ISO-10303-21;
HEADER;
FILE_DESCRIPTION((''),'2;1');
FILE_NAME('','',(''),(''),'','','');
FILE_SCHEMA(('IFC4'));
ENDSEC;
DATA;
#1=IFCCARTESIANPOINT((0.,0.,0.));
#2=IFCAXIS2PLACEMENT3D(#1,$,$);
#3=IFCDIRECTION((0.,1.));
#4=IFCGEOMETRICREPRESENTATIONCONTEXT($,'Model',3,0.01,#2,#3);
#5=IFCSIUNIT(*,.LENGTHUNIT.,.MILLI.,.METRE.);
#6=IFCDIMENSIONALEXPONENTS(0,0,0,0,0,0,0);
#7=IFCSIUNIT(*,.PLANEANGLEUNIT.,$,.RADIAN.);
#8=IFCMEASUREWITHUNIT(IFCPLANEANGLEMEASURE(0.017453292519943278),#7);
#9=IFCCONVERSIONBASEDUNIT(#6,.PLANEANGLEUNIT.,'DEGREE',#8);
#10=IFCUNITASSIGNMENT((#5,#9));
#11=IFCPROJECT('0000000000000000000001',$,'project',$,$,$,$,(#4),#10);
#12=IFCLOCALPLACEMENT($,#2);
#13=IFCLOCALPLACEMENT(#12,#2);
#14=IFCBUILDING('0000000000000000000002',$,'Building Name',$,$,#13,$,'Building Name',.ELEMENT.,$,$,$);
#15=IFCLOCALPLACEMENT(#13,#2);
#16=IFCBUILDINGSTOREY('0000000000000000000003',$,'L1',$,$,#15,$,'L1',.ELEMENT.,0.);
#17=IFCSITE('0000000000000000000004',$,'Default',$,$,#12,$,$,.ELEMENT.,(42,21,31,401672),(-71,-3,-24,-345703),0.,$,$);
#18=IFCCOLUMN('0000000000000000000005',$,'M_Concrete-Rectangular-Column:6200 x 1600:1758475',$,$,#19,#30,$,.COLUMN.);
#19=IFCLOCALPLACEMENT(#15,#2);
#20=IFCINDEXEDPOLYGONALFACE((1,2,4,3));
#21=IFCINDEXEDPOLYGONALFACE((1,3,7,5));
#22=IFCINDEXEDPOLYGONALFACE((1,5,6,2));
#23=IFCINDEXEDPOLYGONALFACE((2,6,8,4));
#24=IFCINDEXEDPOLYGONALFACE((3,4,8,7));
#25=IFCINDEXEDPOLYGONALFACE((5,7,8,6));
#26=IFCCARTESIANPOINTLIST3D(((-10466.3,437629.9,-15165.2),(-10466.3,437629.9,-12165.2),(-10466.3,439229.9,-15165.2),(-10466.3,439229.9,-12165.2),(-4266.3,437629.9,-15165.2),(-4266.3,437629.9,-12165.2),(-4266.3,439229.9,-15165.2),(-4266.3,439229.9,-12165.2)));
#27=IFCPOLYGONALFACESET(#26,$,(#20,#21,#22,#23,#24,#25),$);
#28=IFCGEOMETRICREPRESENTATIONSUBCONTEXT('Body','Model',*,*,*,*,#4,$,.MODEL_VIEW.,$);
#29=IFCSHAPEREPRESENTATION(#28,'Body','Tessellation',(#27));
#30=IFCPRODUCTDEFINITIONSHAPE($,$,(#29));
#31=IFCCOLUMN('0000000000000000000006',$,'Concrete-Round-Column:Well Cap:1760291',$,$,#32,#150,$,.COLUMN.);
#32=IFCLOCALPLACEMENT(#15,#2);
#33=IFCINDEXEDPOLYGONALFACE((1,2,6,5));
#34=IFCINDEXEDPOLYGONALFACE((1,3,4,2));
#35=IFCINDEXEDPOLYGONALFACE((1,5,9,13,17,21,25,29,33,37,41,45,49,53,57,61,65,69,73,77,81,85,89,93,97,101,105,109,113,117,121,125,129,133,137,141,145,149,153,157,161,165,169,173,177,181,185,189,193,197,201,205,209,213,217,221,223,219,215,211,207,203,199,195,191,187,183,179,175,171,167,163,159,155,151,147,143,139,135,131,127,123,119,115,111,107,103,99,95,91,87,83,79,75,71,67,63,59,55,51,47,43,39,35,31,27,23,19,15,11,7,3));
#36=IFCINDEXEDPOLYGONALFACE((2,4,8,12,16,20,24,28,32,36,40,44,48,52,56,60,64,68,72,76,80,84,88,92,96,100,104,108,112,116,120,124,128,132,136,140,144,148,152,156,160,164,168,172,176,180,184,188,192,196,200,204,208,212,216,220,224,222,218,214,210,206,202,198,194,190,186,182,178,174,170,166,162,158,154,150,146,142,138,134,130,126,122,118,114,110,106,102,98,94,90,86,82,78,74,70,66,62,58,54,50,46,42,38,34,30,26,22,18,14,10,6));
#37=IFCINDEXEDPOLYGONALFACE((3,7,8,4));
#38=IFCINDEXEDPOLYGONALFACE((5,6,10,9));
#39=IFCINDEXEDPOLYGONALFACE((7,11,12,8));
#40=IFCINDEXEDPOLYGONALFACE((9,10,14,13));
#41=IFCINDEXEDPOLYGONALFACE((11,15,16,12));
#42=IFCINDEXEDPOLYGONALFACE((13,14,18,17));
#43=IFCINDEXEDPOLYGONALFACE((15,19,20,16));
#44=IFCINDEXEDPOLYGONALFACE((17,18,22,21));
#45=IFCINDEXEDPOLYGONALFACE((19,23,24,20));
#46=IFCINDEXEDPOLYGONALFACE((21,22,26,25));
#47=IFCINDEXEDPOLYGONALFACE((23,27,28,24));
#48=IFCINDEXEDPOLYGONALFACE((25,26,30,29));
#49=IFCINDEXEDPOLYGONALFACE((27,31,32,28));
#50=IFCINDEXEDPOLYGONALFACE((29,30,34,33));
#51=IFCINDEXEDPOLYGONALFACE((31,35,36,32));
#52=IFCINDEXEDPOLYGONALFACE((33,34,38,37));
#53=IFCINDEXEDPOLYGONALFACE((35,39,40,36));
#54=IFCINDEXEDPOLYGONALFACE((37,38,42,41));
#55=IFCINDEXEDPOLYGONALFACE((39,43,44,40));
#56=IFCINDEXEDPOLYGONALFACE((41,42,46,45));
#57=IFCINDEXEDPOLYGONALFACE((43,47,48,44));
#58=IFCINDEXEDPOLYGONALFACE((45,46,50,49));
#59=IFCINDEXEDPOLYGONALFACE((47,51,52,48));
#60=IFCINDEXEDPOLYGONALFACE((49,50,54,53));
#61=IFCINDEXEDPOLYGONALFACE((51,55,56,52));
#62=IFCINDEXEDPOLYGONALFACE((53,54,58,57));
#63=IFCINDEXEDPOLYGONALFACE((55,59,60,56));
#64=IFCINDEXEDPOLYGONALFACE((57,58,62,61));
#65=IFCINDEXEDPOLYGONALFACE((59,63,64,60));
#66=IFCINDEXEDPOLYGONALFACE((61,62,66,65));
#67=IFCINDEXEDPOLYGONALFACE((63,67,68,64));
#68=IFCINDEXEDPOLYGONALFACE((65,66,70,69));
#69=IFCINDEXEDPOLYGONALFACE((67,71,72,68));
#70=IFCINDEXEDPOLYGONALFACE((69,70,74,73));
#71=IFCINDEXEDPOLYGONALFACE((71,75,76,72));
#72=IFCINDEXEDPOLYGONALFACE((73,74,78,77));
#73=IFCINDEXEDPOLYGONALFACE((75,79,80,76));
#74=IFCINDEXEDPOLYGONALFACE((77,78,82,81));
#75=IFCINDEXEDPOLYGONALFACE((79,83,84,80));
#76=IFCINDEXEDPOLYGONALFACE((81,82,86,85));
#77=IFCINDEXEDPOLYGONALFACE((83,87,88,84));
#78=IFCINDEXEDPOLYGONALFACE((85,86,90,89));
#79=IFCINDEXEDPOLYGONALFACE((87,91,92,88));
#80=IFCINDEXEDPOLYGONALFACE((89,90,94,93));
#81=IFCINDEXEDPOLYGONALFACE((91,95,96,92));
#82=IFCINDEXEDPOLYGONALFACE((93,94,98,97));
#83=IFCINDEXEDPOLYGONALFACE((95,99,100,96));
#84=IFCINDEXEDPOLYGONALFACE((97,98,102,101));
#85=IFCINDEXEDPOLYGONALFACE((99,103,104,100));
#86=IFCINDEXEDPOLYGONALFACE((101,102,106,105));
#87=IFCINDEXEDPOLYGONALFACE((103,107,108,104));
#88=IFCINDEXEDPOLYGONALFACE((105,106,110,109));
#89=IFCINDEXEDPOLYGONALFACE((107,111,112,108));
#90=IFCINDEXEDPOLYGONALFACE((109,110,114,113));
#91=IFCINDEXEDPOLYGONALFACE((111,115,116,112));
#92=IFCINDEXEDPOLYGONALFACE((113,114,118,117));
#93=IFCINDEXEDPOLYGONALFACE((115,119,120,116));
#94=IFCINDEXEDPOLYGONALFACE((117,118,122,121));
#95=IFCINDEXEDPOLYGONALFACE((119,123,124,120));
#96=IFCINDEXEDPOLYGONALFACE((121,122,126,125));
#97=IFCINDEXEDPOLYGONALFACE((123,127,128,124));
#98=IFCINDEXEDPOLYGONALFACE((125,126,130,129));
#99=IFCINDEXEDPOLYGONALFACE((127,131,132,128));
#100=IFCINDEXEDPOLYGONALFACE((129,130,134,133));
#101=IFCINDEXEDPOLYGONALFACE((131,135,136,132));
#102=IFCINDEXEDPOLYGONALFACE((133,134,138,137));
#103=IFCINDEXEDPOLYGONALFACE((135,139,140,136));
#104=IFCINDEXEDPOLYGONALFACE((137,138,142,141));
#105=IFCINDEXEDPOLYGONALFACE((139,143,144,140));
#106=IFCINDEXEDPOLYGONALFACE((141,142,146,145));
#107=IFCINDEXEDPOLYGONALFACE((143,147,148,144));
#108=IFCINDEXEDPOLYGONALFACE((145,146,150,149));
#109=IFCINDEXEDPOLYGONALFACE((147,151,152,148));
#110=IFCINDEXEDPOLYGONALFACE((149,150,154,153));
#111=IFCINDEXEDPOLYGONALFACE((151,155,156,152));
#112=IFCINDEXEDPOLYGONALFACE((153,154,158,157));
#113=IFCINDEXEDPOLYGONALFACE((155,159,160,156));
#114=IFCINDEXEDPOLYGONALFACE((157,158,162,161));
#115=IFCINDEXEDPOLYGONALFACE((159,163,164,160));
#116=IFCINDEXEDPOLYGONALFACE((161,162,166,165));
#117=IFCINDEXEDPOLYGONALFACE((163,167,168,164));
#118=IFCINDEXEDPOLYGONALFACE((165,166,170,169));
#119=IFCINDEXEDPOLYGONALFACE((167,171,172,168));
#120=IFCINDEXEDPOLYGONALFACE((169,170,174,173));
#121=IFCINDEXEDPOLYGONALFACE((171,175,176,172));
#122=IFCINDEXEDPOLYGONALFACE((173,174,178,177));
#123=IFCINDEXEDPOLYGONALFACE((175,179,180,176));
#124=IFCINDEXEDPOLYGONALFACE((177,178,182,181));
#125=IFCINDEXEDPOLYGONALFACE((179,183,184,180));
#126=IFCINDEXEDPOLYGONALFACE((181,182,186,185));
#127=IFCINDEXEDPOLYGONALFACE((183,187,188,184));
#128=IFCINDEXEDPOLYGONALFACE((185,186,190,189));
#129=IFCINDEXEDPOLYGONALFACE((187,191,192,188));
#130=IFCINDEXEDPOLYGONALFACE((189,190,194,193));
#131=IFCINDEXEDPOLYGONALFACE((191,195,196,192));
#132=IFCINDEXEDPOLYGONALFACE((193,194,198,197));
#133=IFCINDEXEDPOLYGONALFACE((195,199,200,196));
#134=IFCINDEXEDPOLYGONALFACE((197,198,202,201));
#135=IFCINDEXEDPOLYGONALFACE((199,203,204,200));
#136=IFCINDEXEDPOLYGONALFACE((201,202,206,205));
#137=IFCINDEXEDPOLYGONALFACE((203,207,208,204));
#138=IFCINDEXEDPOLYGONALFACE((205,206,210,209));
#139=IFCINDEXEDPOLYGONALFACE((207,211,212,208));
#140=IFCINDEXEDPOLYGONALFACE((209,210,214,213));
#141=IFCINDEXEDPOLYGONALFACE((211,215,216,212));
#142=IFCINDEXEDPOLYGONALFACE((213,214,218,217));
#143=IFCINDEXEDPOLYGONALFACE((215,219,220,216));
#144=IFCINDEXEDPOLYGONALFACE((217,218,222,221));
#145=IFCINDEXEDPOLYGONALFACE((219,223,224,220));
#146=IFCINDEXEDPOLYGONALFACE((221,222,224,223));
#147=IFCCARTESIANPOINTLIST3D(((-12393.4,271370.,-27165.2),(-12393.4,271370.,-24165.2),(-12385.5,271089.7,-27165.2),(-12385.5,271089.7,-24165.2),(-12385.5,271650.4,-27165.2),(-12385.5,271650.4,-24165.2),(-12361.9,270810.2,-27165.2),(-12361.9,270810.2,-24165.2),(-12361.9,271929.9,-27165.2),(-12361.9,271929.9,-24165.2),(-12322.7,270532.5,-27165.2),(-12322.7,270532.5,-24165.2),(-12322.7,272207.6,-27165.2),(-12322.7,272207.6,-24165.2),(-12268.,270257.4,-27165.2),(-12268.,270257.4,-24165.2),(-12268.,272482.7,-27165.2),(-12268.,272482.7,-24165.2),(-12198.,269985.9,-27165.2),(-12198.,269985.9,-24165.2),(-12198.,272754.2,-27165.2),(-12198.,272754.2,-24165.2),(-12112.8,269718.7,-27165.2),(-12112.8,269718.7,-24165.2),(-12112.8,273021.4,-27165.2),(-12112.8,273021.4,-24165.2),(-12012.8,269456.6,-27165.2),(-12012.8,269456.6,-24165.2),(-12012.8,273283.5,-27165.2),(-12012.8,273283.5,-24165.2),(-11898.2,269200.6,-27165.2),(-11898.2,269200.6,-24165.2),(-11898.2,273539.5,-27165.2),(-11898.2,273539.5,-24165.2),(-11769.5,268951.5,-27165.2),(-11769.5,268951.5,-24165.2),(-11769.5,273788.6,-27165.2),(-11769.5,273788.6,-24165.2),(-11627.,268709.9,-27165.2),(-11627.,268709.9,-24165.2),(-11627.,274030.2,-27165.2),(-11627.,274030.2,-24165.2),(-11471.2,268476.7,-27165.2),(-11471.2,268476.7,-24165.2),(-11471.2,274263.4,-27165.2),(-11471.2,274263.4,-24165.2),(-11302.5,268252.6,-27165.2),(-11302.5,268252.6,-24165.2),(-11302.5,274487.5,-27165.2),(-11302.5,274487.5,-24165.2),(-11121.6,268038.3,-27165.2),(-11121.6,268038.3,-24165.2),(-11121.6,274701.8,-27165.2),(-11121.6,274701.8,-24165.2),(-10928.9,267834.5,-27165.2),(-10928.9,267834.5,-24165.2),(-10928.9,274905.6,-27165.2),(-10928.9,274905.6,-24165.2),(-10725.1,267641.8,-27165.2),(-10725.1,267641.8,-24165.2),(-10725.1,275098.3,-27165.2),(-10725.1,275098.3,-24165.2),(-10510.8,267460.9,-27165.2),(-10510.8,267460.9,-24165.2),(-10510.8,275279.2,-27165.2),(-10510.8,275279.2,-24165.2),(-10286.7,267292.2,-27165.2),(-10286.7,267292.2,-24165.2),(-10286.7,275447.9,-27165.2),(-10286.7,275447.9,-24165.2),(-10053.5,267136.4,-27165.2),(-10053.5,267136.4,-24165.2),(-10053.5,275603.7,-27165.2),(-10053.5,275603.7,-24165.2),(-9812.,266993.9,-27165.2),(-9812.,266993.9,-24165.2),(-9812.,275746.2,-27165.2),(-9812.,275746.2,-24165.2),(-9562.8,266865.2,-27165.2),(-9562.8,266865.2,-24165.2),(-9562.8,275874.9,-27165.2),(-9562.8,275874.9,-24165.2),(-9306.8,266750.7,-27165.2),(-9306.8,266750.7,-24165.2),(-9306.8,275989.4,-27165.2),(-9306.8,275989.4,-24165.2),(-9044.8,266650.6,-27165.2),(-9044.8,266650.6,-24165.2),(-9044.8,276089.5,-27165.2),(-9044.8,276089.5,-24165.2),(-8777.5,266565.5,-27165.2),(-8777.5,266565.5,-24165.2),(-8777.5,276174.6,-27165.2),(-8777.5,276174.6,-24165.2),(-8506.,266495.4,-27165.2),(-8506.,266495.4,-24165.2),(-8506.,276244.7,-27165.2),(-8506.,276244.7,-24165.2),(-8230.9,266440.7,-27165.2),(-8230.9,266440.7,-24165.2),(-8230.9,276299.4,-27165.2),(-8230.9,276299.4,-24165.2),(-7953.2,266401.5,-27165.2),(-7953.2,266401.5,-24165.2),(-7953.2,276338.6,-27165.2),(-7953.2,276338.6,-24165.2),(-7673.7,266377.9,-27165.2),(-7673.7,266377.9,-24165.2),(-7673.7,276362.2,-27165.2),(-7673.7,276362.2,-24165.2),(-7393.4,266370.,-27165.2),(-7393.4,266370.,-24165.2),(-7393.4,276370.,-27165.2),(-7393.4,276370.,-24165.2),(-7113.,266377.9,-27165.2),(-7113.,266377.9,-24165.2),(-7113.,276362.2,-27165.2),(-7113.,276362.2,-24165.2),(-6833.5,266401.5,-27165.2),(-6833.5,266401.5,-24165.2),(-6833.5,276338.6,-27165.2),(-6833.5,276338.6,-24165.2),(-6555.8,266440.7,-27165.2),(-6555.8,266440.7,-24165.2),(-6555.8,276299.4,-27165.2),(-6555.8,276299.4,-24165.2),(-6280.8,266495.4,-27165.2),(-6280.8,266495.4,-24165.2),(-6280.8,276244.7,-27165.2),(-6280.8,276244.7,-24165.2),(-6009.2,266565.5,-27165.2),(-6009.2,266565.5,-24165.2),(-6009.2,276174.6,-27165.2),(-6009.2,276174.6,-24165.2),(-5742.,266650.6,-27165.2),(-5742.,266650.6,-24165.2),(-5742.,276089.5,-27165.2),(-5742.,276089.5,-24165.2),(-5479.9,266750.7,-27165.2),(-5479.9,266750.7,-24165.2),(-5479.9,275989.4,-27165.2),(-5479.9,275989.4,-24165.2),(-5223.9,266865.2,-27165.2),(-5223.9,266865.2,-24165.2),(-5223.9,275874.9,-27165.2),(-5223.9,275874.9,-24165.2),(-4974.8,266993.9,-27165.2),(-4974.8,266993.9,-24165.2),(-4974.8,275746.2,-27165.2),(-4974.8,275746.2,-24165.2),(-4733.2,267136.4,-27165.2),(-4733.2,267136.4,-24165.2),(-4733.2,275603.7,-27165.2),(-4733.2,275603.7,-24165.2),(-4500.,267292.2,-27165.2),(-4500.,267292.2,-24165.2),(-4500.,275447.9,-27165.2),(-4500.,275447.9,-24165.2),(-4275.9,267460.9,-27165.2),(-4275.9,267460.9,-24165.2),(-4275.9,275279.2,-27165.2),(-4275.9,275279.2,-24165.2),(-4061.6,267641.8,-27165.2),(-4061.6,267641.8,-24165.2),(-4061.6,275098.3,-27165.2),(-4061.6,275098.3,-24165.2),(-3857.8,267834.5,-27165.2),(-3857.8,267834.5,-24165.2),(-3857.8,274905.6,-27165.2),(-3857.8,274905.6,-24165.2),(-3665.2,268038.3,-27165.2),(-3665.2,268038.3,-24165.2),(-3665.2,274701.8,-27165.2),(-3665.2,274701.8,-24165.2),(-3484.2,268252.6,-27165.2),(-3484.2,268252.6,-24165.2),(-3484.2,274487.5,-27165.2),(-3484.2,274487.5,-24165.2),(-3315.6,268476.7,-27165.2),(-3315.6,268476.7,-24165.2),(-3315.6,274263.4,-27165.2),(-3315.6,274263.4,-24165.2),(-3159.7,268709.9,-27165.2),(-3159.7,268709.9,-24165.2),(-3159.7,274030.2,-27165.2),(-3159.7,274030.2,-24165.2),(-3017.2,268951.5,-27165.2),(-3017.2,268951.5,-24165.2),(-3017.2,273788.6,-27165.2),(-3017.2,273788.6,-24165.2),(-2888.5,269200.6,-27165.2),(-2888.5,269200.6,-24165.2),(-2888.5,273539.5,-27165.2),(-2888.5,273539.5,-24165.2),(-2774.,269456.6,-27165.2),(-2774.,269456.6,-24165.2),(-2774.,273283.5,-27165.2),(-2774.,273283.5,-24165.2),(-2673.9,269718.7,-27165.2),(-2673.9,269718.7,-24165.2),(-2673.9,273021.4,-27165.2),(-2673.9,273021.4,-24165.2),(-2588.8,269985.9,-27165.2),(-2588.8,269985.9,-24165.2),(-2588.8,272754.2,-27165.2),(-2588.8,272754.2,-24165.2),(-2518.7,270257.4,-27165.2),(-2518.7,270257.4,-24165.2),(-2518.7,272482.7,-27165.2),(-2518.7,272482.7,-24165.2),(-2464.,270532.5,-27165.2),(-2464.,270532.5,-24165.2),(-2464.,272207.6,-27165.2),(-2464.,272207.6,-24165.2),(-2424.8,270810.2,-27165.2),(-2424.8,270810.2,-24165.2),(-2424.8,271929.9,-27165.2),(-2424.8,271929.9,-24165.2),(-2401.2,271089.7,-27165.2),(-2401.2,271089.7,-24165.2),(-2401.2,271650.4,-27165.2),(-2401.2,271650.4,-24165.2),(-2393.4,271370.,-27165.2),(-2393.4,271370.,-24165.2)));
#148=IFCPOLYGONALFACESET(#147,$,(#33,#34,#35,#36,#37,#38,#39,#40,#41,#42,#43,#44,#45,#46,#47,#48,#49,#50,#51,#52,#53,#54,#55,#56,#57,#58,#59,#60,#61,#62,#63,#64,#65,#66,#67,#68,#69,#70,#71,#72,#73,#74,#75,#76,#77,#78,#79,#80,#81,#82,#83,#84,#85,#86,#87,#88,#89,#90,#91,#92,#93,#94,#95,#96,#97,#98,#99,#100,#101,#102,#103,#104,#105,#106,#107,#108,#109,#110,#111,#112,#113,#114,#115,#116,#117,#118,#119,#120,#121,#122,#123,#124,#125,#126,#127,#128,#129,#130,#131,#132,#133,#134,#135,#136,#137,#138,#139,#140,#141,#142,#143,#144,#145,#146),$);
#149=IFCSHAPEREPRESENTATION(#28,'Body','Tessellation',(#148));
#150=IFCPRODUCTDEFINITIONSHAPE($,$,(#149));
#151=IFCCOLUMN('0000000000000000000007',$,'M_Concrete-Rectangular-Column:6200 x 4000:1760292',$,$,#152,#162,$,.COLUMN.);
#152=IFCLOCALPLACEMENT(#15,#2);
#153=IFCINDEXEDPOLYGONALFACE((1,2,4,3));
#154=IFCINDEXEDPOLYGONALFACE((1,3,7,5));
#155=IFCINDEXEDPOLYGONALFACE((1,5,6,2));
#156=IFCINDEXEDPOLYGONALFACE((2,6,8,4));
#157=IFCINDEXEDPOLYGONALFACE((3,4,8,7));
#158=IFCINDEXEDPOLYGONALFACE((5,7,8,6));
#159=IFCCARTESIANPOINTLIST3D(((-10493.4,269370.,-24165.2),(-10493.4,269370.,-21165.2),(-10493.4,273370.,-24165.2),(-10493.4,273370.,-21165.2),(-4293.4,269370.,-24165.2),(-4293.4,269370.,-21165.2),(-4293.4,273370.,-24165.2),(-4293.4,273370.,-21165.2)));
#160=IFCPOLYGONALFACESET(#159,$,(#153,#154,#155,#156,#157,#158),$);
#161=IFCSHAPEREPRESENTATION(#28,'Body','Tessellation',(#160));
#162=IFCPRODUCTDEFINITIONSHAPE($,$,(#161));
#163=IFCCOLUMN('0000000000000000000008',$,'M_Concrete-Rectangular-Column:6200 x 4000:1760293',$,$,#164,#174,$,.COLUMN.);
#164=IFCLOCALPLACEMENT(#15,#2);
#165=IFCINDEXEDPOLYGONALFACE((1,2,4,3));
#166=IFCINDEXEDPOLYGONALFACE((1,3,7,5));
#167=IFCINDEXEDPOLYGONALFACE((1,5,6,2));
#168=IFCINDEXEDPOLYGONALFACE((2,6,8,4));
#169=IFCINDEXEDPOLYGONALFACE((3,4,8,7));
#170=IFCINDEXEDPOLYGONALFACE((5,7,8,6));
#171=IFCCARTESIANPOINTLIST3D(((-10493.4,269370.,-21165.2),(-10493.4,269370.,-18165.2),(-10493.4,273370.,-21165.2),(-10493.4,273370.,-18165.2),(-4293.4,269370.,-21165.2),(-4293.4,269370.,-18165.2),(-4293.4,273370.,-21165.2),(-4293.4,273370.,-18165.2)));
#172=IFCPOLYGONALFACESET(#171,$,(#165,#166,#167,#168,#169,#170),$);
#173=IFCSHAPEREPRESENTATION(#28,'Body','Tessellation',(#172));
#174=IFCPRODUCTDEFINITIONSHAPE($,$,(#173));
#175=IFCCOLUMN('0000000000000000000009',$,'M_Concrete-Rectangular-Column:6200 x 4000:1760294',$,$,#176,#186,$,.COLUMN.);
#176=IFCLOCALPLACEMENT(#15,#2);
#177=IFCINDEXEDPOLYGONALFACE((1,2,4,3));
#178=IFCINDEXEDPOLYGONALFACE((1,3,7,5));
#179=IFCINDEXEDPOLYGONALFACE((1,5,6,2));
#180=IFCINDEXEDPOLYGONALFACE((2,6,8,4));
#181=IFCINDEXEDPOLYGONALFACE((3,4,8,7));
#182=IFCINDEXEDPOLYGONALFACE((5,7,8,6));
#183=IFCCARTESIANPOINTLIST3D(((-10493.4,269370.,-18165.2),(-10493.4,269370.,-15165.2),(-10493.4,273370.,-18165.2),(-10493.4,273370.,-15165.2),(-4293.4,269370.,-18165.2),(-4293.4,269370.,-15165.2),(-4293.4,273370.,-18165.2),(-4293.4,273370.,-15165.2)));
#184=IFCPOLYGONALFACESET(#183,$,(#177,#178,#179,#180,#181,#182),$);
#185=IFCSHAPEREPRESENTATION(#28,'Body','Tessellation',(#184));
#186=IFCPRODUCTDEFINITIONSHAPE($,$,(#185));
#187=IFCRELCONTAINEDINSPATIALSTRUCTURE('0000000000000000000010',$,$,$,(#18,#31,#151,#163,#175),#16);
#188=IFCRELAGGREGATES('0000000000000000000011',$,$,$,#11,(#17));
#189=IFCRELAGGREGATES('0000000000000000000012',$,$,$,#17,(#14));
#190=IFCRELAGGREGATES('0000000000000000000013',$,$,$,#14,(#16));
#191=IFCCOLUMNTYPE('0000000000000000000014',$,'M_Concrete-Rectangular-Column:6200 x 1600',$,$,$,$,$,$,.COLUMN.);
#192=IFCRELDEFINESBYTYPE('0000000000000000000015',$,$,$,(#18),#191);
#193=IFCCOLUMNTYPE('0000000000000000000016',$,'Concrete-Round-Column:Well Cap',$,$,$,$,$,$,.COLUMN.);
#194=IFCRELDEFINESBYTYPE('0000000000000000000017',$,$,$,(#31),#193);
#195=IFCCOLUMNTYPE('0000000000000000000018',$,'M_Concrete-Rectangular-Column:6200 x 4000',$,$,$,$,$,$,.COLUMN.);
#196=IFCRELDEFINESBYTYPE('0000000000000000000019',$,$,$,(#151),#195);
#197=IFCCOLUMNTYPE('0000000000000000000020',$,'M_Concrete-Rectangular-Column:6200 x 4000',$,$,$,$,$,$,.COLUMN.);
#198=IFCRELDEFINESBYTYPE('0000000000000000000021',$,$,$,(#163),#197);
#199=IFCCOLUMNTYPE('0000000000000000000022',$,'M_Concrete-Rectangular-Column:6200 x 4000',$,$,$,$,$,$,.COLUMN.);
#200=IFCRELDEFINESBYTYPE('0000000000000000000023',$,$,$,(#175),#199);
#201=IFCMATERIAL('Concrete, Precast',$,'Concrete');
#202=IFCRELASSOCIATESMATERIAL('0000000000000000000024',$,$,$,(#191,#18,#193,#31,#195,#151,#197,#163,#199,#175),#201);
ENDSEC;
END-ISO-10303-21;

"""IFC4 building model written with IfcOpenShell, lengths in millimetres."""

from ifc_helpers import new_model, entity, si_unit, converted_unit, direction, frame, origin, place, context, subcontext, project, spatial, arc, indexed_curve, outline, extrude, source, transform, mapped, material, type_object, type_shapes, element, save


model = new_model("IFC4")

# Units and contexts
model_context = context("Model", 3, precision=0.01, world=origin(), true_north=direction((0.0, 1.0)))
body_context = subcontext(model_context, "Body", "Model", "MODEL_VIEW")
ifc_project = project(units=[si_unit("LENGTHUNIT", "METRE", prefix="MILLI"), converted_unit("PLANEANGLEUNIT", "DEGREE", entity("IfcPlaneAngleMeasure", 0.017453292519943278), si_unit("PLANEANGLEUNIT", "RADIAN"), dimensions=[0, 0, 0, 0, 0, 0, 0])], contexts=[model_context])

# Site, building, storey
site_placement = place(None, origin())
site = spatial("IfcSite", under=ifc_project, at=site_placement, Name="Default", CompositionType="ELEMENT", RefLatitude=(42, 21, 31, 401672), RefLongitude=(-71, -3, -24, -345703), RefElevation=0.0)
building_placement = place(site_placement, origin())
building = spatial("IfcBuilding", under=site, at=building_placement, Name="Building Name", LongName="Building Name", CompositionType="ELEMENT")
storey_placement = place(building_placement, origin())
storey = spatial("IfcBuildingStorey", under=building, at=storey_placement, Name="L1", LongName="L1", CompositionType="ELEMENT", Elevation=0.0)

# Columns
ifc_material_1 = material(Name="Concrete, Precast", Category="Concrete")
column_type_1 = type_object("IfcColumnType", Name="M_Concrete-Rectangular-Column:6200 x 1600", PredefinedType="COLUMN", material=ifc_material_1)
shared_shape_1 = source(origin(), body_context, "Body", "SweptSolid", [
    extrude(outline(indexed_curve([(-800.0, -3100.0), (800.0, -3100.0), (800.0, 3100.0), (-800.0, 3100.0), (-800.0, -3100.0)], self_intersect=False)), frame((-7366.3, 438429.9, -15165.2), z_axis=(0.0, 0.0, 1.0), x_axis=(0.0, -1.0, 0.0)), (0.0, 0.0, 1.0), 3000.0),
])
type_shapes(column_type_1, [shared_shape_1])
column_1_placement = place(storey_placement, origin())
element("IfcColumn", 1, at=column_1_placement, inside=storey, type_object=column_type_1, material=ifc_material_1, Name="M_Concrete-Rectangular-Column:6200 x 1600:1758475", PredefinedType="COLUMN", context=body_context, shape_type="MappedRepresentation", body=[
    mapped(shared_shape_1, transform((0.0, 0.0, 0.0), scale=1.0)),
])
column_type_2 = type_object("IfcColumnType", Name="Concrete-Round-Column:Well Cap", PredefinedType="COLUMN", material=ifc_material_1)
shared_shape_2 = source(origin(), body_context, "Body", "SweptSolid", [
    extrude(outline(indexed_curve([(5000.0, 0.0), (0.0, 5000.0), (-5000.0, 0.0), (0.0, -5000.0)], segments=[arc(1, 2, 3), arc(3, 4, 1)], self_intersect=False)), frame((-7393.4, 271370.0, -27165.2)), (0.0, 0.0, 1.0), 3000.0),
])
type_shapes(column_type_2, [shared_shape_2])
column_2_placement = place(storey_placement, origin())
element("IfcColumn", 2, at=column_2_placement, inside=storey, type_object=column_type_2, material=ifc_material_1, Name="Concrete-Round-Column:Well Cap:1760291", PredefinedType="COLUMN", context=body_context, shape_type="MappedRepresentation", body=[
    mapped(shared_shape_2, transform((0.0, 0.0, 0.0), scale=1.0)),
])
column_type_3 = type_object("IfcColumnType", Name="M_Concrete-Rectangular-Column:6200 x 4000", PredefinedType="COLUMN", material=ifc_material_1)
shared_shape_3 = source(origin(), body_context, "Body", "SweptSolid", [
    extrude(outline(indexed_curve([(-2000.0, -3100.0), (2000.0, -3100.0), (2000.0, 3100.0), (-2000.0, 3100.0), (-2000.0, -3100.0)], self_intersect=False)), frame((-7393.4, 271370.0, -24165.2), z_axis=(0.0, 0.0, 1.0), x_axis=(0.0, -1.0, 0.0)), (0.0, 0.0, 1.0), 3000.0),
])
type_shapes(column_type_3, [shared_shape_3])
column_3_placement = place(storey_placement, origin())
element("IfcColumn", 3, at=column_3_placement, inside=storey, type_object=column_type_3, material=ifc_material_1, Name="M_Concrete-Rectangular-Column:6200 x 4000:1760292", PredefinedType="COLUMN", context=body_context, shape_type="MappedRepresentation", body=[
    mapped(shared_shape_3, transform((0.0, 0.0, 0.0), scale=1.0)),
])
column_type_4 = type_object("IfcColumnType", Name="M_Concrete-Rectangular-Column:6200 x 4000", PredefinedType="COLUMN", material=ifc_material_1)
shared_shape_4 = source(origin(), body_context, "Body", "SweptSolid", [
    extrude(outline(indexed_curve([(-2000.0, -3100.0), (2000.0, -3100.0), (2000.0, 3100.0), (-2000.0, 3100.0), (-2000.0, -3100.0)], self_intersect=False)), frame((-7393.4, 271370.0, -21165.2), z_axis=(0.0, 0.0, 1.0), x_axis=(0.0, -1.0, 0.0)), (0.0, 0.0, 1.0), 3000.0),
])
type_shapes(column_type_4, [shared_shape_4])
column_4_placement = place(storey_placement, origin())
element("IfcColumn", 4, at=column_4_placement, inside=storey, type_object=column_type_4, material=ifc_material_1, Name="M_Concrete-Rectangular-Column:6200 x 4000:1760293", PredefinedType="COLUMN", context=body_context, shape_type="MappedRepresentation", body=[
    mapped(shared_shape_4, transform((0.0, 0.0, 0.0), scale=1.0)),
])
column_type_5 = type_object("IfcColumnType", Name="M_Concrete-Rectangular-Column:6200 x 4000", PredefinedType="COLUMN", material=ifc_material_1)
shared_shape_5 = source(origin(), body_context, "Body", "SweptSolid", [
    extrude(outline(indexed_curve([(-2000.0, -3100.0), (2000.0, -3100.0), (2000.0, 3100.0), (-2000.0, 3100.0), (-2000.0, -3100.0)], self_intersect=False)), frame((-7393.4, 271370.0, -18165.2), z_axis=(0.0, 0.0, 1.0), x_axis=(0.0, -1.0, 0.0)), (0.0, 0.0, 1.0), 3000.0),
])
type_shapes(column_type_5, [shared_shape_5])
column_5_placement = place(storey_placement, origin())
element("IfcColumn", 5, at=column_5_placement, inside=storey, type_object=column_type_5, material=ifc_material_1, Name="M_Concrete-Rectangular-Column:6200 x 4000:1760294", PredefinedType="COLUMN", context=body_context, shape_type="MappedRepresentation", body=[
    mapped(shared_shape_5, transform((0.0, 0.0, 0.0), scale=1.0)),
])

save(model, "model.ifc")
